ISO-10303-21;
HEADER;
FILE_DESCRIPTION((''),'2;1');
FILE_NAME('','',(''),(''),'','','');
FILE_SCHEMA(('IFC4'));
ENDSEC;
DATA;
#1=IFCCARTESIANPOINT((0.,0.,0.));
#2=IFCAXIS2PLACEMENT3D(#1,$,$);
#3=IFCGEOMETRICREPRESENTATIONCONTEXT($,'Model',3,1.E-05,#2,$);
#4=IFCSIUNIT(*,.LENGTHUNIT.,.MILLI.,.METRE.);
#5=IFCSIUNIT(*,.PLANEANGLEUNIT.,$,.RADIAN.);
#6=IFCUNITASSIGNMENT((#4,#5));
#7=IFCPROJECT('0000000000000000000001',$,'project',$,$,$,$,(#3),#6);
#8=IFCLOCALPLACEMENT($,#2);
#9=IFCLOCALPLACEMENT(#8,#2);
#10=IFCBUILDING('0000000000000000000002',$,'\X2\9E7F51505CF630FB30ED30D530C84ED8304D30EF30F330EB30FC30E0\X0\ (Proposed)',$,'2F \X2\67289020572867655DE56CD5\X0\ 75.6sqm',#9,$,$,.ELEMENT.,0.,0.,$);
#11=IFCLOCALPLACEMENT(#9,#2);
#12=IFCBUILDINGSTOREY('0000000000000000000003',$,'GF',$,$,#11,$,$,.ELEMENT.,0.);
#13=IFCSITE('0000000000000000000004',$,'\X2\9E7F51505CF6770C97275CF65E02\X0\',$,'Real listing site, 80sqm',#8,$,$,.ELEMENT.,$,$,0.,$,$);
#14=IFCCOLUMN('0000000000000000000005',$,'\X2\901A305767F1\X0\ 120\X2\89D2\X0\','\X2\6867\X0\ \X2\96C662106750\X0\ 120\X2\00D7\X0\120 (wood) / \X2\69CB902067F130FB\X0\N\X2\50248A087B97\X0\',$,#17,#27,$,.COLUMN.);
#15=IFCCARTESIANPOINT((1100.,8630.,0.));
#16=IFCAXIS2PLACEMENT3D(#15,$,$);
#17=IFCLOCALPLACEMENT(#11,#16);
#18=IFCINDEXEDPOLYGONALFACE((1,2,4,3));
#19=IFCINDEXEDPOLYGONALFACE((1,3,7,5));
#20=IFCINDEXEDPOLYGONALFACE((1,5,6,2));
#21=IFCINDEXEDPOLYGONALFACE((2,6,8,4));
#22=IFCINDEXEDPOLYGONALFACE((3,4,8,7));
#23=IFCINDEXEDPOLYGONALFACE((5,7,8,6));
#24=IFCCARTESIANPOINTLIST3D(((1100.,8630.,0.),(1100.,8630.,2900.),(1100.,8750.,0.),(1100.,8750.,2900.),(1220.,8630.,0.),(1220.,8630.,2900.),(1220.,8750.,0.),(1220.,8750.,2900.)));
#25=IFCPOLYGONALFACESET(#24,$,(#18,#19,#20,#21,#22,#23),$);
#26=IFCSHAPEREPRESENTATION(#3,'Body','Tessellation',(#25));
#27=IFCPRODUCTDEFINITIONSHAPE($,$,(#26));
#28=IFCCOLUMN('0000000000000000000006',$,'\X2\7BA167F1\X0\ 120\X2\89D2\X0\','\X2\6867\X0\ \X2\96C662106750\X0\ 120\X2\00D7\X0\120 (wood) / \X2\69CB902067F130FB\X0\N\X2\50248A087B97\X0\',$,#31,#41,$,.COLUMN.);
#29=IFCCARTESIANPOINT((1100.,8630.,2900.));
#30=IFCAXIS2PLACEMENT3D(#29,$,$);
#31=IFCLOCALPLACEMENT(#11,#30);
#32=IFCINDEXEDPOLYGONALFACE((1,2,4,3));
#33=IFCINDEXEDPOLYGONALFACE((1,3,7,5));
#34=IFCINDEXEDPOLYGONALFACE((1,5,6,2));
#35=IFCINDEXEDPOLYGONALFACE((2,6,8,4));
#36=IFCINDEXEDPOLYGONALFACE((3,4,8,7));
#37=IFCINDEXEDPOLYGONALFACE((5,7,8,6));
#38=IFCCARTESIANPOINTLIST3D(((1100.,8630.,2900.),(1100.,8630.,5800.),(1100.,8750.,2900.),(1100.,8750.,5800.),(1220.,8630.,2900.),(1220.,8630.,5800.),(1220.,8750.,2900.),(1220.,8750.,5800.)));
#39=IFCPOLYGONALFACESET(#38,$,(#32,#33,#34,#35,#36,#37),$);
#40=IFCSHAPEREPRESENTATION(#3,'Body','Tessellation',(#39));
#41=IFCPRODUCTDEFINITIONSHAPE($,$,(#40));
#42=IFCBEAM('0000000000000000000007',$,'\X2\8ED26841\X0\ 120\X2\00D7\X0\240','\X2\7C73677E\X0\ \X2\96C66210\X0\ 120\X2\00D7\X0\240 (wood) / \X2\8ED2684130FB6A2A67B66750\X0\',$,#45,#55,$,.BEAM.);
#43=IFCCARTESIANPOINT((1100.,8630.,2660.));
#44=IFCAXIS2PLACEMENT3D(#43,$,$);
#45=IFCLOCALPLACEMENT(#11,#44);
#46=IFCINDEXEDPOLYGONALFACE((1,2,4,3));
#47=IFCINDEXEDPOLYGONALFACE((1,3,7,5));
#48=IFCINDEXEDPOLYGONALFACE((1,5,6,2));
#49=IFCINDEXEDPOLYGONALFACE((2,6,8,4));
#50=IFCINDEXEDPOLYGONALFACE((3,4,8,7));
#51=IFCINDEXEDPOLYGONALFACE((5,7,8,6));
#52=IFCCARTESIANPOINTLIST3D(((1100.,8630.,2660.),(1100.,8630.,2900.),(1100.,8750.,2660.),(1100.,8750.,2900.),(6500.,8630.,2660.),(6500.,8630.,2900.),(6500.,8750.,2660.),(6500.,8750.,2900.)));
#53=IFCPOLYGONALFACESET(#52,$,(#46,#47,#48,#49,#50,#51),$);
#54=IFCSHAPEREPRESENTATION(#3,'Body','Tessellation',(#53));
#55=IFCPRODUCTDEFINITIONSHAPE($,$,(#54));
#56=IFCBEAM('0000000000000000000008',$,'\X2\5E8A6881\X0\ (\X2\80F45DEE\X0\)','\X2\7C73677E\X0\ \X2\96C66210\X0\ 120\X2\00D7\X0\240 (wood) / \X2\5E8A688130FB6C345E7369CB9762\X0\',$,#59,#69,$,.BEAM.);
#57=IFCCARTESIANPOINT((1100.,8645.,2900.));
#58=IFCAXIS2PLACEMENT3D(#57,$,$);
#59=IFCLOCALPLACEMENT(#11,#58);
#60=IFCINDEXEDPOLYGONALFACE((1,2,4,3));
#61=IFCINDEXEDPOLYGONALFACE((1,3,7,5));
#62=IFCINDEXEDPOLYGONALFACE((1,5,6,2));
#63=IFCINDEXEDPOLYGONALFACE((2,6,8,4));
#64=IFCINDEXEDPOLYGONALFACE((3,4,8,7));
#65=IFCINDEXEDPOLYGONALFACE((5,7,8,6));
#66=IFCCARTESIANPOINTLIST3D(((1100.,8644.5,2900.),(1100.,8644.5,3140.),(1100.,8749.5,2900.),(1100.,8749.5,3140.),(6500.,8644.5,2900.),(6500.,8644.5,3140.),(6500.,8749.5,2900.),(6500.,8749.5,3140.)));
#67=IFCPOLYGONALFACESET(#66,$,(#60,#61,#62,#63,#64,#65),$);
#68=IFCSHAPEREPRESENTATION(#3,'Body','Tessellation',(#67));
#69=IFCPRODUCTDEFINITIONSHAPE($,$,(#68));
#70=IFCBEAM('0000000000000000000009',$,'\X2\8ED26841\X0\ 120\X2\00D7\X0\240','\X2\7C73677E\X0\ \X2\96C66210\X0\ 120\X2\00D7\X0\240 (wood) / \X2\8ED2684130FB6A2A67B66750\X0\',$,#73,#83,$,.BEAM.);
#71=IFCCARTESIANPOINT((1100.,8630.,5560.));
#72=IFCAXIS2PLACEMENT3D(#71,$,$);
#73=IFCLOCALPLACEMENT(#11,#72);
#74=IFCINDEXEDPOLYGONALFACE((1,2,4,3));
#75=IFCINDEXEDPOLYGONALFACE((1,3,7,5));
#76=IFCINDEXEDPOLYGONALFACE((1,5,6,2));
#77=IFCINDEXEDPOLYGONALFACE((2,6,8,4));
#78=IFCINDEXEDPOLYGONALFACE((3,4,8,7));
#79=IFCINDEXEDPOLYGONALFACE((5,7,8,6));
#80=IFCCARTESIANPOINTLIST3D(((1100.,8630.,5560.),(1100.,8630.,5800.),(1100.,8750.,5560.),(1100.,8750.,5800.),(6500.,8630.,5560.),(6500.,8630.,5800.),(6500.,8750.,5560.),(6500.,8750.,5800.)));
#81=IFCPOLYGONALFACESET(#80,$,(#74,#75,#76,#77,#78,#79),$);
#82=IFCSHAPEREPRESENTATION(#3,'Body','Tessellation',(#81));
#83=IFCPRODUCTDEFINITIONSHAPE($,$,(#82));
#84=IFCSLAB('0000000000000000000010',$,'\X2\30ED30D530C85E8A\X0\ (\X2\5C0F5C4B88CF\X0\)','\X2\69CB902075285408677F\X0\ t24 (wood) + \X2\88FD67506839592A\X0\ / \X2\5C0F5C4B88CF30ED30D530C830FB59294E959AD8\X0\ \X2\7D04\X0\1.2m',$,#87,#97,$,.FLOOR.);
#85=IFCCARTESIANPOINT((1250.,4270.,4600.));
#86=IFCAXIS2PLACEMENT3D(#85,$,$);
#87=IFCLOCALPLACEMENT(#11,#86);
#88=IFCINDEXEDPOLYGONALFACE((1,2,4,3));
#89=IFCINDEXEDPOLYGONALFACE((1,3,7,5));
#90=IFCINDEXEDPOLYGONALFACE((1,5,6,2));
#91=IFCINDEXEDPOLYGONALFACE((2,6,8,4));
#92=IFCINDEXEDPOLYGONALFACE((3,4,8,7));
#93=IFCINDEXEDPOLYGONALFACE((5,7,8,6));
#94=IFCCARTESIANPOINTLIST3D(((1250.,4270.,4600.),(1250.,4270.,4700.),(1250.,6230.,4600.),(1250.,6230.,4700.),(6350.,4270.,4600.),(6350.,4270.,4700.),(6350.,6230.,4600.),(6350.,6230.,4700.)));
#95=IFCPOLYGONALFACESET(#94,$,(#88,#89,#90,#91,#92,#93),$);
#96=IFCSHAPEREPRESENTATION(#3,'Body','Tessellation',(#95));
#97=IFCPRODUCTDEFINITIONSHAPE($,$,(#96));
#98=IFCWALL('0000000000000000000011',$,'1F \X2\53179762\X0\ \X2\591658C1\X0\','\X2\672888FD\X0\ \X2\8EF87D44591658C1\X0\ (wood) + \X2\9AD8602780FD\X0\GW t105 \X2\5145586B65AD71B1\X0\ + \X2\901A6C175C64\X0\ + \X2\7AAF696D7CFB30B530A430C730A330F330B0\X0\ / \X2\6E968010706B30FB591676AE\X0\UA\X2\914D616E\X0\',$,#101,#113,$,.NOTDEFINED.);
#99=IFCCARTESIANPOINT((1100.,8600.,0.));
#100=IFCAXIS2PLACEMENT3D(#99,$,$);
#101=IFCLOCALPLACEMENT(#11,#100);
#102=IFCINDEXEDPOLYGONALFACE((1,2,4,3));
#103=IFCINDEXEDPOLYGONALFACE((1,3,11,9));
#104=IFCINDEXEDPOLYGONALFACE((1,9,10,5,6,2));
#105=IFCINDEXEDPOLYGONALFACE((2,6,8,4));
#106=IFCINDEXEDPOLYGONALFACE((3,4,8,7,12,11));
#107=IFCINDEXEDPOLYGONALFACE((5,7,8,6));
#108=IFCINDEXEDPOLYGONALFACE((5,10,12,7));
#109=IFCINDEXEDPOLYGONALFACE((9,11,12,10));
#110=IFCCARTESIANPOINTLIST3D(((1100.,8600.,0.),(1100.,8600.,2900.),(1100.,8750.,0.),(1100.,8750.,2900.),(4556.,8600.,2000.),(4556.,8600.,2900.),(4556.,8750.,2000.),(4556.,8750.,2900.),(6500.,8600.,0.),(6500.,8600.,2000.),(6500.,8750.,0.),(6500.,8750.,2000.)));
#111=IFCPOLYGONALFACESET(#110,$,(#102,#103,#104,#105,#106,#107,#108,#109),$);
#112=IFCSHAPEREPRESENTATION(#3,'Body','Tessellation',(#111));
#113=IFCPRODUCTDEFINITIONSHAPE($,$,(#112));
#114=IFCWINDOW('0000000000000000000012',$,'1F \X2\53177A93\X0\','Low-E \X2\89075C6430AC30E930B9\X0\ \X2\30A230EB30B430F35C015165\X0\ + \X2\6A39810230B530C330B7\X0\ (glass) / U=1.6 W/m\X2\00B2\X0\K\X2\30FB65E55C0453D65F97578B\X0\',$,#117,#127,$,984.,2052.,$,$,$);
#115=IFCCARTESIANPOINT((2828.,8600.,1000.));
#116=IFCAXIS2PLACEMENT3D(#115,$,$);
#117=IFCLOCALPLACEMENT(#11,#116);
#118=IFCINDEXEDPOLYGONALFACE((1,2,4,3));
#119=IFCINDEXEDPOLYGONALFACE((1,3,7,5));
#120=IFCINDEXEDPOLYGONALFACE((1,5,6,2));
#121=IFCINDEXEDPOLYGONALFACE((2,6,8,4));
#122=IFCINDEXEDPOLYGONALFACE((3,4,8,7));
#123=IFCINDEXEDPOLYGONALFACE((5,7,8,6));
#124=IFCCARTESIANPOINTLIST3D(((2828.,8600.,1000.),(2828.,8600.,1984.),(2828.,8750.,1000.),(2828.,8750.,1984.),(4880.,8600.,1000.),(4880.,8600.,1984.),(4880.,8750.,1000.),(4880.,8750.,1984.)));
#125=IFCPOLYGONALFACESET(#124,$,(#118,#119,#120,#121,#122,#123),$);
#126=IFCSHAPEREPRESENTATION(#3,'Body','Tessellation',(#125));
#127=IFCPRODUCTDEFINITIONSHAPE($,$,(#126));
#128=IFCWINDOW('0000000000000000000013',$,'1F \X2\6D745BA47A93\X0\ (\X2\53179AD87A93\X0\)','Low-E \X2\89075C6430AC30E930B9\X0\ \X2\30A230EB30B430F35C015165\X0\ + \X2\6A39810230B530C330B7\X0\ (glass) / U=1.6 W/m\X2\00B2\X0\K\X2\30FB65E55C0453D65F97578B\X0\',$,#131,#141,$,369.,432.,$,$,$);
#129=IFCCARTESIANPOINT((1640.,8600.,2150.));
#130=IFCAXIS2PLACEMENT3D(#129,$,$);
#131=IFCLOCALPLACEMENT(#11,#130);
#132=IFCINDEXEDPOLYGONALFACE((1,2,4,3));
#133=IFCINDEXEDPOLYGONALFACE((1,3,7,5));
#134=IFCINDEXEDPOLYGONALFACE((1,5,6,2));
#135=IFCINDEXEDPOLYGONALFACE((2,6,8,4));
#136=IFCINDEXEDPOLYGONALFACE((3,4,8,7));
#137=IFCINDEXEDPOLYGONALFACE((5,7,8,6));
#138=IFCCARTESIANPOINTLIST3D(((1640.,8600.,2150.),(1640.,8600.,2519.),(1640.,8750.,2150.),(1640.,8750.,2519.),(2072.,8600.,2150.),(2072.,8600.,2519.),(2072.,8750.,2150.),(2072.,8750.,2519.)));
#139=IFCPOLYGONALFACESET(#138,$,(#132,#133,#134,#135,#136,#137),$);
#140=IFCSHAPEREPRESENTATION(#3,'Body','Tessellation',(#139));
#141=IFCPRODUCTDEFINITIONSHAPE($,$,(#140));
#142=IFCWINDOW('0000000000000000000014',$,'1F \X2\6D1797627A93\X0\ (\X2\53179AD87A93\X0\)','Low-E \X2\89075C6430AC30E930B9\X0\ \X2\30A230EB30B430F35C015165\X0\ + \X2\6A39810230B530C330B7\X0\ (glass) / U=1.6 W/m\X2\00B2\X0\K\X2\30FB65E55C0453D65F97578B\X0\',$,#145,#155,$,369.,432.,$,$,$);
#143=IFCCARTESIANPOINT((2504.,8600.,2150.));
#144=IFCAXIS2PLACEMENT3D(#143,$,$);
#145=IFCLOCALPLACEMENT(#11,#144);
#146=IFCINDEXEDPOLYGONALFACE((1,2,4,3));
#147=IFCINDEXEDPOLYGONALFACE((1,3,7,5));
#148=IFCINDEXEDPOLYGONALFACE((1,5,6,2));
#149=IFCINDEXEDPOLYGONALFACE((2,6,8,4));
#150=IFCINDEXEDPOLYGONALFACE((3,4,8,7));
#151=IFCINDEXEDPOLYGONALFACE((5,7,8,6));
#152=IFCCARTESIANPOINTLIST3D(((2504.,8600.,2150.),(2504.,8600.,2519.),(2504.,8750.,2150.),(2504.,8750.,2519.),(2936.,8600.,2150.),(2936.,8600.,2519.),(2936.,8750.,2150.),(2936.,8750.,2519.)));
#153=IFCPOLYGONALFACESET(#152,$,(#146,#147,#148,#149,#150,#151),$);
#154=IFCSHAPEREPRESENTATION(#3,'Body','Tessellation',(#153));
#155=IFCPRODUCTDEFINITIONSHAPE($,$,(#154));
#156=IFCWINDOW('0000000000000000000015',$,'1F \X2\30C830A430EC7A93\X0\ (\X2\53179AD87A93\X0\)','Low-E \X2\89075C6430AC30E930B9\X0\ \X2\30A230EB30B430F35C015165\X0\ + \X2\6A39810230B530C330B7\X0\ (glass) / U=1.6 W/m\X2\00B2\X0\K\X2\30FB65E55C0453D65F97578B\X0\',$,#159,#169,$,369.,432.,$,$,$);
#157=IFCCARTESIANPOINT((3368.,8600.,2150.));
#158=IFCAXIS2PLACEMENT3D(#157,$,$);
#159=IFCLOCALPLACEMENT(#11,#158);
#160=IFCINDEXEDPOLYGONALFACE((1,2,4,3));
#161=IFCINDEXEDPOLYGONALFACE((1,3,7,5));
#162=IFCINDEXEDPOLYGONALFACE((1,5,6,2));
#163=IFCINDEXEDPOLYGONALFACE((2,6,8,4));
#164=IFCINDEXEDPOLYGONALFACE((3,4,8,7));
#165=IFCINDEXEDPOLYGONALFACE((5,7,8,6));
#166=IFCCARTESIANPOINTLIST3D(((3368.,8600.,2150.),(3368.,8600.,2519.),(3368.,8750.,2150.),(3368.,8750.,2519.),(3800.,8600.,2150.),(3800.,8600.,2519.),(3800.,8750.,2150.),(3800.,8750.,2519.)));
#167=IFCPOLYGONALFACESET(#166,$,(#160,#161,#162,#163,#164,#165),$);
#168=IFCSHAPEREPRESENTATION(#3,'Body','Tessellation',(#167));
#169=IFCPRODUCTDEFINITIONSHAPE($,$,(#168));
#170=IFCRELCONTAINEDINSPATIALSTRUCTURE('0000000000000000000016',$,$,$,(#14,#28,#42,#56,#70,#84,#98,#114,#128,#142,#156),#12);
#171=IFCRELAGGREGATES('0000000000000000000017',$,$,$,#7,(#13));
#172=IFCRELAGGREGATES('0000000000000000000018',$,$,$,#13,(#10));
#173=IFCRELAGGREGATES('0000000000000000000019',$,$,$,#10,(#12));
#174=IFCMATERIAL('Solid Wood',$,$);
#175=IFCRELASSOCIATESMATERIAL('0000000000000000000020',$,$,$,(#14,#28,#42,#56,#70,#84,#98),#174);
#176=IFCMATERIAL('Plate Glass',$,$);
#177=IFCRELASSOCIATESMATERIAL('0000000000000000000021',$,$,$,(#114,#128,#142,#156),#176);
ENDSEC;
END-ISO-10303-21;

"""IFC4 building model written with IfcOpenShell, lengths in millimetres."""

from ifc_helpers import new_model, si_unit, frame, frame_2d, origin, place, context, project, spatial, rectangle, extrude, material, element, fill, save


model = new_model("IFC4")

# Units and contexts
model_context = context("Model", 3, precision=1e-05, world=origin())
ifc_project = project(units=[si_unit("LENGTHUNIT", "METRE", prefix="MILLI"), si_unit("PLANEANGLEUNIT", "RADIAN")], contexts=[model_context])

# Site, building, storey
site_placement = place(None, origin())
site = spatial("IfcSite", under=ifc_project, at=site_placement, Name="鹿児島県霧島市", ObjectType="Real listing site, 80sqm", CompositionType="ELEMENT", RefElevation=0.0)
building_placement = place(site_placement, origin())
building = spatial("IfcBuilding", under=site, at=building_placement, Name="鹿児島・ロフト付きワンルーム (Proposed)", ObjectType="2F 木造在来工法 75.6sqm", CompositionType="ELEMENT", ElevationOfRefHeight=0.0, ElevationOfTerrain=0.0)
storey_placement = place(building_placement, origin())
storey = spatial("IfcBuildingStorey", under=building, at=storey_placement, Name="GF", CompositionType="ELEMENT", Elevation=0.0)

# Columns
ifc_material_1 = material(Name="Solid Wood")
column_1_placement = place(storey_placement, frame((1100.0, 8630.0, 0.0)))
element("IfcColumn", 1, at=column_1_placement, inside=storey, material=ifc_material_1, Name="通し柱 120角", Description="桧 集成材 120×120 (wood) / 構造柱・N値計算", PredefinedType="COLUMN", context=model_context, shape_type="SweptSolid", body=[
    extrude(rectangle(XDim=120.0, YDim=120.0, at=frame_2d((60.0, 60.0))), frame((1100.0, 8630.0, 0.0)), (0.0, 0.0, 1.0), 2900.0),
])
column_2_placement = place(storey_placement, frame((1100.0, 8630.0, 2900.0)))
element("IfcColumn", 2, at=column_2_placement, inside=storey, material=ifc_material_1, Name="管柱 120角", Description="桧 集成材 120×120 (wood) / 構造柱・N値計算", PredefinedType="COLUMN", context=model_context, shape_type="SweptSolid", body=[
    extrude(rectangle(XDim=120.0, YDim=120.0, at=frame_2d((60.0, 60.0))), frame((1100.0, 8630.0, 2900.0)), (0.0, 0.0, 1.0), 2900.0),
])

# Beams
beam_1_placement = place(storey_placement, frame((1100.0, 8630.0, 2660.0)))
element("IfcBeam", 3, at=beam_1_placement, inside=storey, material=ifc_material_1, Name="軒桁 120×240", Description="米松 集成 120×240 (wood) / 軒桁・横架材", PredefinedType="BEAM", context=model_context, shape_type="SweptSolid", body=[
    extrude(rectangle(XDim=5400.0, YDim=120.0, at=frame_2d((2700.0, 60.0))), frame((1100.0, 8630.0, 2660.0)), (0.0, 0.0, 1.0), 240.0),
])
beam_2_placement = place(storey_placement, frame((1100.0, 8645.0, 2900.0)))
element("IfcBeam", 4, at=beam_2_placement, inside=storey, material=ifc_material_1, Name="床梁 (胴差)", Description="米松 集成 120×240 (wood) / 床梁・水平構面", PredefinedType="BEAM", context=model_context, shape_type="SweptSolid", body=[
    extrude(rectangle(XDim=5400.0, YDim=105.0, at=frame_2d((2700.0, 52.0))), frame((1100.0, 8645.0, 2900.0)), (0.0, 0.0, 1.0), 240.0),
])
beam_3_placement = place(storey_placement, frame((1100.0, 8630.0, 5560.0)))
element("IfcBeam", 5, at=beam_3_placement, inside=storey, material=ifc_material_1, Name="軒桁 120×240", Description="米松 集成 120×240 (wood) / 軒桁・横架材", PredefinedType="BEAM", context=model_context, shape_type="SweptSolid", body=[
    extrude(rectangle(XDim=5400.0, YDim=120.0, at=frame_2d((2700.0, 60.0))), frame((1100.0, 8630.0, 5560.0)), (0.0, 0.0, 1.0), 240.0),
])

# Slab
slab_placement = place(storey_placement, frame((1250.0, 4270.0, 4600.0)))
element("IfcSlab", 6, at=slab_placement, inside=storey, material=ifc_material_1, Name="ロフト床 (小屋裏)", Description="構造用合板 t24 (wood) + 製材根太 / 小屋裏ロフト・天井高 約1.2m", PredefinedType="FLOOR", context=model_context, shape_type="SweptSolid", body=[
    extrude(rectangle(XDim=5100.0, YDim=1960.0, at=frame_2d((2550.0, 980.0))), frame((1250.0, 4270.0, 4600.0)), (0.0, 0.0, 1.0), 100.0),
])

# Wall, openings, windows
wall_1_placement = place(storey_placement, frame((1100.0, 8600.0, 0.0)))
wall_1 = element("IfcWall", 7, at=wall_1_placement, inside=storey, material=ifc_material_1, Name="1F 北面 外壁", Description="木製 軸組外壁 (wood) + 高性能GW t105 充填断熱 + 通気層 + 窯業系サイディング / 準耐火・外皮UA配慮", PredefinedType="NOTDEFINED", context=model_context, shape_type="SweptSolid", body=[
    extrude(rectangle(XDim=5400.0, YDim=150.0, at=frame_2d((2700.0, 75.0))), frame((1100.0, 8600.0, 0.0)), (0.0, 0.0, 1.0), 2900.0),
])
opening_1_placement = place(storey_placement, frame((2828.0, 8600.0, 1000.0)))
opening_1 = element("IfcOpeningElement", 8, at=opening_1_placement, cuts=wall_1, PredefinedType="NOTDEFINED", context=model_context, shape_type="SweptSolid", body=[
    extrude(rectangle(XDim=2052.0, YDim=150.0, at=frame_2d((1026.0, 75.0))), frame((2828.0, 8600.0, 1000.0)), (0.0, 0.0, 1.0), 984.0),
])
opening_2_placement = place(storey_placement, frame((1640.0, 8600.0, 2150.0)))
opening_2 = element("IfcOpeningElement", 9, at=opening_2_placement, cuts=wall_1, PredefinedType="NOTDEFINED", context=model_context, shape_type="SweptSolid", body=[
    extrude(rectangle(XDim=432.0, YDim=150.0, at=frame_2d((216.0, 75.0))), frame((1640.0, 8600.0, 2150.0)), (0.0, 0.0, 1.0), 369.0),
])
opening_3_placement = place(storey_placement, frame((2504.0, 8600.0, 2150.0)))
opening_3 = element("IfcOpeningElement", 10, at=opening_3_placement, cuts=wall_1, PredefinedType="NOTDEFINED", context=model_context, shape_type="SweptSolid", body=[
    extrude(rectangle(XDim=432.0, YDim=150.0, at=frame_2d((216.0, 75.0))), frame((2504.0, 8600.0, 2150.0)), (0.0, 0.0, 1.0), 369.0),
])
opening_4_placement = place(storey_placement, frame((3368.0, 8600.0, 2150.0)))
opening_4 = element("IfcOpeningElement", 11, at=opening_4_placement, cuts=wall_1, PredefinedType="NOTDEFINED", context=model_context, shape_type="SweptSolid", body=[
    extrude(rectangle(XDim=432.0, YDim=150.0, at=frame_2d((216.0, 75.0))), frame((3368.0, 8600.0, 2150.0)), (0.0, 0.0, 1.0), 369.0),
])
ifc_material_2 = material(Name="Plate Glass")
window_1_placement = place(storey_placement, frame((2828.0, 8600.0, 1000.0)))
window_1 = element("IfcWindow", 12, at=window_1_placement, inside=storey, material=ifc_material_2, Name="1F 北窓", Description="Low-E 複層ガラス アルゴン封入 + 樹脂サッシ (glass) / U=1.6 W/m²K・日射取得型", OverallHeight=984.0, OverallWidth=2052.0, context=model_context, shape_type="SweptSolid", body=[
    extrude(rectangle(XDim=2052.0, YDim=150.0, at=frame_2d((1026.0, 75.0))), frame((2828.0, 8600.0, 1000.0)), (0.0, 0.0, 1.0), 984.0),
])
fill(opening_1, window_1)
window_2_placement = place(storey_placement, frame((1640.0, 8600.0, 2150.0)))
window_2 = element("IfcWindow", 13, at=window_2_placement, inside=storey, material=ifc_material_2, Name="1F 浴室窓 (北高窓)", Description="Low-E 複層ガラス アルゴン封入 + 樹脂サッシ (glass) / U=1.6 W/m²K・日射取得型", OverallHeight=369.0, OverallWidth=432.0, context=model_context, shape_type="SweptSolid", body=[
    extrude(rectangle(XDim=432.0, YDim=150.0, at=frame_2d((216.0, 75.0))), frame((1640.0, 8600.0, 2150.0)), (0.0, 0.0, 1.0), 369.0),
])
fill(opening_2, window_2)
window_3_placement = place(storey_placement, frame((2504.0, 8600.0, 2150.0)))
window_3 = element("IfcWindow", 14, at=window_3_placement, inside=storey, material=ifc_material_2, Name="1F 洗面窓 (北高窓)", Description="Low-E 複層ガラス アルゴン封入 + 樹脂サッシ (glass) / U=1.6 W/m²K・日射取得型", OverallHeight=369.0, OverallWidth=432.0, context=model_context, shape_type="SweptSolid", body=[
    extrude(rectangle(XDim=432.0, YDim=150.0, at=frame_2d((216.0, 75.0))), frame((2504.0, 8600.0, 2150.0)), (0.0, 0.0, 1.0), 369.0),
])
fill(opening_3, window_3)
window_4_placement = place(storey_placement, frame((3368.0, 8600.0, 2150.0)))
window_4 = element("IfcWindow", 15, at=window_4_placement, inside=storey, material=ifc_material_2, Name="1F トイレ窓 (北高窓)", Description="Low-E 複層ガラス アルゴン封入 + 樹脂サッシ (glass) / U=1.6 W/m²K・日射取得型", OverallHeight=369.0, OverallWidth=432.0, context=model_context, shape_type="SweptSolid", body=[
    extrude(rectangle(XDim=432.0, YDim=150.0, at=frame_2d((216.0, 75.0))), frame((3368.0, 8600.0, 2150.0)), (0.0, 0.0, 1.0), 369.0),
])
fill(opening_4, window_4)

save(model, "model.ifc")
